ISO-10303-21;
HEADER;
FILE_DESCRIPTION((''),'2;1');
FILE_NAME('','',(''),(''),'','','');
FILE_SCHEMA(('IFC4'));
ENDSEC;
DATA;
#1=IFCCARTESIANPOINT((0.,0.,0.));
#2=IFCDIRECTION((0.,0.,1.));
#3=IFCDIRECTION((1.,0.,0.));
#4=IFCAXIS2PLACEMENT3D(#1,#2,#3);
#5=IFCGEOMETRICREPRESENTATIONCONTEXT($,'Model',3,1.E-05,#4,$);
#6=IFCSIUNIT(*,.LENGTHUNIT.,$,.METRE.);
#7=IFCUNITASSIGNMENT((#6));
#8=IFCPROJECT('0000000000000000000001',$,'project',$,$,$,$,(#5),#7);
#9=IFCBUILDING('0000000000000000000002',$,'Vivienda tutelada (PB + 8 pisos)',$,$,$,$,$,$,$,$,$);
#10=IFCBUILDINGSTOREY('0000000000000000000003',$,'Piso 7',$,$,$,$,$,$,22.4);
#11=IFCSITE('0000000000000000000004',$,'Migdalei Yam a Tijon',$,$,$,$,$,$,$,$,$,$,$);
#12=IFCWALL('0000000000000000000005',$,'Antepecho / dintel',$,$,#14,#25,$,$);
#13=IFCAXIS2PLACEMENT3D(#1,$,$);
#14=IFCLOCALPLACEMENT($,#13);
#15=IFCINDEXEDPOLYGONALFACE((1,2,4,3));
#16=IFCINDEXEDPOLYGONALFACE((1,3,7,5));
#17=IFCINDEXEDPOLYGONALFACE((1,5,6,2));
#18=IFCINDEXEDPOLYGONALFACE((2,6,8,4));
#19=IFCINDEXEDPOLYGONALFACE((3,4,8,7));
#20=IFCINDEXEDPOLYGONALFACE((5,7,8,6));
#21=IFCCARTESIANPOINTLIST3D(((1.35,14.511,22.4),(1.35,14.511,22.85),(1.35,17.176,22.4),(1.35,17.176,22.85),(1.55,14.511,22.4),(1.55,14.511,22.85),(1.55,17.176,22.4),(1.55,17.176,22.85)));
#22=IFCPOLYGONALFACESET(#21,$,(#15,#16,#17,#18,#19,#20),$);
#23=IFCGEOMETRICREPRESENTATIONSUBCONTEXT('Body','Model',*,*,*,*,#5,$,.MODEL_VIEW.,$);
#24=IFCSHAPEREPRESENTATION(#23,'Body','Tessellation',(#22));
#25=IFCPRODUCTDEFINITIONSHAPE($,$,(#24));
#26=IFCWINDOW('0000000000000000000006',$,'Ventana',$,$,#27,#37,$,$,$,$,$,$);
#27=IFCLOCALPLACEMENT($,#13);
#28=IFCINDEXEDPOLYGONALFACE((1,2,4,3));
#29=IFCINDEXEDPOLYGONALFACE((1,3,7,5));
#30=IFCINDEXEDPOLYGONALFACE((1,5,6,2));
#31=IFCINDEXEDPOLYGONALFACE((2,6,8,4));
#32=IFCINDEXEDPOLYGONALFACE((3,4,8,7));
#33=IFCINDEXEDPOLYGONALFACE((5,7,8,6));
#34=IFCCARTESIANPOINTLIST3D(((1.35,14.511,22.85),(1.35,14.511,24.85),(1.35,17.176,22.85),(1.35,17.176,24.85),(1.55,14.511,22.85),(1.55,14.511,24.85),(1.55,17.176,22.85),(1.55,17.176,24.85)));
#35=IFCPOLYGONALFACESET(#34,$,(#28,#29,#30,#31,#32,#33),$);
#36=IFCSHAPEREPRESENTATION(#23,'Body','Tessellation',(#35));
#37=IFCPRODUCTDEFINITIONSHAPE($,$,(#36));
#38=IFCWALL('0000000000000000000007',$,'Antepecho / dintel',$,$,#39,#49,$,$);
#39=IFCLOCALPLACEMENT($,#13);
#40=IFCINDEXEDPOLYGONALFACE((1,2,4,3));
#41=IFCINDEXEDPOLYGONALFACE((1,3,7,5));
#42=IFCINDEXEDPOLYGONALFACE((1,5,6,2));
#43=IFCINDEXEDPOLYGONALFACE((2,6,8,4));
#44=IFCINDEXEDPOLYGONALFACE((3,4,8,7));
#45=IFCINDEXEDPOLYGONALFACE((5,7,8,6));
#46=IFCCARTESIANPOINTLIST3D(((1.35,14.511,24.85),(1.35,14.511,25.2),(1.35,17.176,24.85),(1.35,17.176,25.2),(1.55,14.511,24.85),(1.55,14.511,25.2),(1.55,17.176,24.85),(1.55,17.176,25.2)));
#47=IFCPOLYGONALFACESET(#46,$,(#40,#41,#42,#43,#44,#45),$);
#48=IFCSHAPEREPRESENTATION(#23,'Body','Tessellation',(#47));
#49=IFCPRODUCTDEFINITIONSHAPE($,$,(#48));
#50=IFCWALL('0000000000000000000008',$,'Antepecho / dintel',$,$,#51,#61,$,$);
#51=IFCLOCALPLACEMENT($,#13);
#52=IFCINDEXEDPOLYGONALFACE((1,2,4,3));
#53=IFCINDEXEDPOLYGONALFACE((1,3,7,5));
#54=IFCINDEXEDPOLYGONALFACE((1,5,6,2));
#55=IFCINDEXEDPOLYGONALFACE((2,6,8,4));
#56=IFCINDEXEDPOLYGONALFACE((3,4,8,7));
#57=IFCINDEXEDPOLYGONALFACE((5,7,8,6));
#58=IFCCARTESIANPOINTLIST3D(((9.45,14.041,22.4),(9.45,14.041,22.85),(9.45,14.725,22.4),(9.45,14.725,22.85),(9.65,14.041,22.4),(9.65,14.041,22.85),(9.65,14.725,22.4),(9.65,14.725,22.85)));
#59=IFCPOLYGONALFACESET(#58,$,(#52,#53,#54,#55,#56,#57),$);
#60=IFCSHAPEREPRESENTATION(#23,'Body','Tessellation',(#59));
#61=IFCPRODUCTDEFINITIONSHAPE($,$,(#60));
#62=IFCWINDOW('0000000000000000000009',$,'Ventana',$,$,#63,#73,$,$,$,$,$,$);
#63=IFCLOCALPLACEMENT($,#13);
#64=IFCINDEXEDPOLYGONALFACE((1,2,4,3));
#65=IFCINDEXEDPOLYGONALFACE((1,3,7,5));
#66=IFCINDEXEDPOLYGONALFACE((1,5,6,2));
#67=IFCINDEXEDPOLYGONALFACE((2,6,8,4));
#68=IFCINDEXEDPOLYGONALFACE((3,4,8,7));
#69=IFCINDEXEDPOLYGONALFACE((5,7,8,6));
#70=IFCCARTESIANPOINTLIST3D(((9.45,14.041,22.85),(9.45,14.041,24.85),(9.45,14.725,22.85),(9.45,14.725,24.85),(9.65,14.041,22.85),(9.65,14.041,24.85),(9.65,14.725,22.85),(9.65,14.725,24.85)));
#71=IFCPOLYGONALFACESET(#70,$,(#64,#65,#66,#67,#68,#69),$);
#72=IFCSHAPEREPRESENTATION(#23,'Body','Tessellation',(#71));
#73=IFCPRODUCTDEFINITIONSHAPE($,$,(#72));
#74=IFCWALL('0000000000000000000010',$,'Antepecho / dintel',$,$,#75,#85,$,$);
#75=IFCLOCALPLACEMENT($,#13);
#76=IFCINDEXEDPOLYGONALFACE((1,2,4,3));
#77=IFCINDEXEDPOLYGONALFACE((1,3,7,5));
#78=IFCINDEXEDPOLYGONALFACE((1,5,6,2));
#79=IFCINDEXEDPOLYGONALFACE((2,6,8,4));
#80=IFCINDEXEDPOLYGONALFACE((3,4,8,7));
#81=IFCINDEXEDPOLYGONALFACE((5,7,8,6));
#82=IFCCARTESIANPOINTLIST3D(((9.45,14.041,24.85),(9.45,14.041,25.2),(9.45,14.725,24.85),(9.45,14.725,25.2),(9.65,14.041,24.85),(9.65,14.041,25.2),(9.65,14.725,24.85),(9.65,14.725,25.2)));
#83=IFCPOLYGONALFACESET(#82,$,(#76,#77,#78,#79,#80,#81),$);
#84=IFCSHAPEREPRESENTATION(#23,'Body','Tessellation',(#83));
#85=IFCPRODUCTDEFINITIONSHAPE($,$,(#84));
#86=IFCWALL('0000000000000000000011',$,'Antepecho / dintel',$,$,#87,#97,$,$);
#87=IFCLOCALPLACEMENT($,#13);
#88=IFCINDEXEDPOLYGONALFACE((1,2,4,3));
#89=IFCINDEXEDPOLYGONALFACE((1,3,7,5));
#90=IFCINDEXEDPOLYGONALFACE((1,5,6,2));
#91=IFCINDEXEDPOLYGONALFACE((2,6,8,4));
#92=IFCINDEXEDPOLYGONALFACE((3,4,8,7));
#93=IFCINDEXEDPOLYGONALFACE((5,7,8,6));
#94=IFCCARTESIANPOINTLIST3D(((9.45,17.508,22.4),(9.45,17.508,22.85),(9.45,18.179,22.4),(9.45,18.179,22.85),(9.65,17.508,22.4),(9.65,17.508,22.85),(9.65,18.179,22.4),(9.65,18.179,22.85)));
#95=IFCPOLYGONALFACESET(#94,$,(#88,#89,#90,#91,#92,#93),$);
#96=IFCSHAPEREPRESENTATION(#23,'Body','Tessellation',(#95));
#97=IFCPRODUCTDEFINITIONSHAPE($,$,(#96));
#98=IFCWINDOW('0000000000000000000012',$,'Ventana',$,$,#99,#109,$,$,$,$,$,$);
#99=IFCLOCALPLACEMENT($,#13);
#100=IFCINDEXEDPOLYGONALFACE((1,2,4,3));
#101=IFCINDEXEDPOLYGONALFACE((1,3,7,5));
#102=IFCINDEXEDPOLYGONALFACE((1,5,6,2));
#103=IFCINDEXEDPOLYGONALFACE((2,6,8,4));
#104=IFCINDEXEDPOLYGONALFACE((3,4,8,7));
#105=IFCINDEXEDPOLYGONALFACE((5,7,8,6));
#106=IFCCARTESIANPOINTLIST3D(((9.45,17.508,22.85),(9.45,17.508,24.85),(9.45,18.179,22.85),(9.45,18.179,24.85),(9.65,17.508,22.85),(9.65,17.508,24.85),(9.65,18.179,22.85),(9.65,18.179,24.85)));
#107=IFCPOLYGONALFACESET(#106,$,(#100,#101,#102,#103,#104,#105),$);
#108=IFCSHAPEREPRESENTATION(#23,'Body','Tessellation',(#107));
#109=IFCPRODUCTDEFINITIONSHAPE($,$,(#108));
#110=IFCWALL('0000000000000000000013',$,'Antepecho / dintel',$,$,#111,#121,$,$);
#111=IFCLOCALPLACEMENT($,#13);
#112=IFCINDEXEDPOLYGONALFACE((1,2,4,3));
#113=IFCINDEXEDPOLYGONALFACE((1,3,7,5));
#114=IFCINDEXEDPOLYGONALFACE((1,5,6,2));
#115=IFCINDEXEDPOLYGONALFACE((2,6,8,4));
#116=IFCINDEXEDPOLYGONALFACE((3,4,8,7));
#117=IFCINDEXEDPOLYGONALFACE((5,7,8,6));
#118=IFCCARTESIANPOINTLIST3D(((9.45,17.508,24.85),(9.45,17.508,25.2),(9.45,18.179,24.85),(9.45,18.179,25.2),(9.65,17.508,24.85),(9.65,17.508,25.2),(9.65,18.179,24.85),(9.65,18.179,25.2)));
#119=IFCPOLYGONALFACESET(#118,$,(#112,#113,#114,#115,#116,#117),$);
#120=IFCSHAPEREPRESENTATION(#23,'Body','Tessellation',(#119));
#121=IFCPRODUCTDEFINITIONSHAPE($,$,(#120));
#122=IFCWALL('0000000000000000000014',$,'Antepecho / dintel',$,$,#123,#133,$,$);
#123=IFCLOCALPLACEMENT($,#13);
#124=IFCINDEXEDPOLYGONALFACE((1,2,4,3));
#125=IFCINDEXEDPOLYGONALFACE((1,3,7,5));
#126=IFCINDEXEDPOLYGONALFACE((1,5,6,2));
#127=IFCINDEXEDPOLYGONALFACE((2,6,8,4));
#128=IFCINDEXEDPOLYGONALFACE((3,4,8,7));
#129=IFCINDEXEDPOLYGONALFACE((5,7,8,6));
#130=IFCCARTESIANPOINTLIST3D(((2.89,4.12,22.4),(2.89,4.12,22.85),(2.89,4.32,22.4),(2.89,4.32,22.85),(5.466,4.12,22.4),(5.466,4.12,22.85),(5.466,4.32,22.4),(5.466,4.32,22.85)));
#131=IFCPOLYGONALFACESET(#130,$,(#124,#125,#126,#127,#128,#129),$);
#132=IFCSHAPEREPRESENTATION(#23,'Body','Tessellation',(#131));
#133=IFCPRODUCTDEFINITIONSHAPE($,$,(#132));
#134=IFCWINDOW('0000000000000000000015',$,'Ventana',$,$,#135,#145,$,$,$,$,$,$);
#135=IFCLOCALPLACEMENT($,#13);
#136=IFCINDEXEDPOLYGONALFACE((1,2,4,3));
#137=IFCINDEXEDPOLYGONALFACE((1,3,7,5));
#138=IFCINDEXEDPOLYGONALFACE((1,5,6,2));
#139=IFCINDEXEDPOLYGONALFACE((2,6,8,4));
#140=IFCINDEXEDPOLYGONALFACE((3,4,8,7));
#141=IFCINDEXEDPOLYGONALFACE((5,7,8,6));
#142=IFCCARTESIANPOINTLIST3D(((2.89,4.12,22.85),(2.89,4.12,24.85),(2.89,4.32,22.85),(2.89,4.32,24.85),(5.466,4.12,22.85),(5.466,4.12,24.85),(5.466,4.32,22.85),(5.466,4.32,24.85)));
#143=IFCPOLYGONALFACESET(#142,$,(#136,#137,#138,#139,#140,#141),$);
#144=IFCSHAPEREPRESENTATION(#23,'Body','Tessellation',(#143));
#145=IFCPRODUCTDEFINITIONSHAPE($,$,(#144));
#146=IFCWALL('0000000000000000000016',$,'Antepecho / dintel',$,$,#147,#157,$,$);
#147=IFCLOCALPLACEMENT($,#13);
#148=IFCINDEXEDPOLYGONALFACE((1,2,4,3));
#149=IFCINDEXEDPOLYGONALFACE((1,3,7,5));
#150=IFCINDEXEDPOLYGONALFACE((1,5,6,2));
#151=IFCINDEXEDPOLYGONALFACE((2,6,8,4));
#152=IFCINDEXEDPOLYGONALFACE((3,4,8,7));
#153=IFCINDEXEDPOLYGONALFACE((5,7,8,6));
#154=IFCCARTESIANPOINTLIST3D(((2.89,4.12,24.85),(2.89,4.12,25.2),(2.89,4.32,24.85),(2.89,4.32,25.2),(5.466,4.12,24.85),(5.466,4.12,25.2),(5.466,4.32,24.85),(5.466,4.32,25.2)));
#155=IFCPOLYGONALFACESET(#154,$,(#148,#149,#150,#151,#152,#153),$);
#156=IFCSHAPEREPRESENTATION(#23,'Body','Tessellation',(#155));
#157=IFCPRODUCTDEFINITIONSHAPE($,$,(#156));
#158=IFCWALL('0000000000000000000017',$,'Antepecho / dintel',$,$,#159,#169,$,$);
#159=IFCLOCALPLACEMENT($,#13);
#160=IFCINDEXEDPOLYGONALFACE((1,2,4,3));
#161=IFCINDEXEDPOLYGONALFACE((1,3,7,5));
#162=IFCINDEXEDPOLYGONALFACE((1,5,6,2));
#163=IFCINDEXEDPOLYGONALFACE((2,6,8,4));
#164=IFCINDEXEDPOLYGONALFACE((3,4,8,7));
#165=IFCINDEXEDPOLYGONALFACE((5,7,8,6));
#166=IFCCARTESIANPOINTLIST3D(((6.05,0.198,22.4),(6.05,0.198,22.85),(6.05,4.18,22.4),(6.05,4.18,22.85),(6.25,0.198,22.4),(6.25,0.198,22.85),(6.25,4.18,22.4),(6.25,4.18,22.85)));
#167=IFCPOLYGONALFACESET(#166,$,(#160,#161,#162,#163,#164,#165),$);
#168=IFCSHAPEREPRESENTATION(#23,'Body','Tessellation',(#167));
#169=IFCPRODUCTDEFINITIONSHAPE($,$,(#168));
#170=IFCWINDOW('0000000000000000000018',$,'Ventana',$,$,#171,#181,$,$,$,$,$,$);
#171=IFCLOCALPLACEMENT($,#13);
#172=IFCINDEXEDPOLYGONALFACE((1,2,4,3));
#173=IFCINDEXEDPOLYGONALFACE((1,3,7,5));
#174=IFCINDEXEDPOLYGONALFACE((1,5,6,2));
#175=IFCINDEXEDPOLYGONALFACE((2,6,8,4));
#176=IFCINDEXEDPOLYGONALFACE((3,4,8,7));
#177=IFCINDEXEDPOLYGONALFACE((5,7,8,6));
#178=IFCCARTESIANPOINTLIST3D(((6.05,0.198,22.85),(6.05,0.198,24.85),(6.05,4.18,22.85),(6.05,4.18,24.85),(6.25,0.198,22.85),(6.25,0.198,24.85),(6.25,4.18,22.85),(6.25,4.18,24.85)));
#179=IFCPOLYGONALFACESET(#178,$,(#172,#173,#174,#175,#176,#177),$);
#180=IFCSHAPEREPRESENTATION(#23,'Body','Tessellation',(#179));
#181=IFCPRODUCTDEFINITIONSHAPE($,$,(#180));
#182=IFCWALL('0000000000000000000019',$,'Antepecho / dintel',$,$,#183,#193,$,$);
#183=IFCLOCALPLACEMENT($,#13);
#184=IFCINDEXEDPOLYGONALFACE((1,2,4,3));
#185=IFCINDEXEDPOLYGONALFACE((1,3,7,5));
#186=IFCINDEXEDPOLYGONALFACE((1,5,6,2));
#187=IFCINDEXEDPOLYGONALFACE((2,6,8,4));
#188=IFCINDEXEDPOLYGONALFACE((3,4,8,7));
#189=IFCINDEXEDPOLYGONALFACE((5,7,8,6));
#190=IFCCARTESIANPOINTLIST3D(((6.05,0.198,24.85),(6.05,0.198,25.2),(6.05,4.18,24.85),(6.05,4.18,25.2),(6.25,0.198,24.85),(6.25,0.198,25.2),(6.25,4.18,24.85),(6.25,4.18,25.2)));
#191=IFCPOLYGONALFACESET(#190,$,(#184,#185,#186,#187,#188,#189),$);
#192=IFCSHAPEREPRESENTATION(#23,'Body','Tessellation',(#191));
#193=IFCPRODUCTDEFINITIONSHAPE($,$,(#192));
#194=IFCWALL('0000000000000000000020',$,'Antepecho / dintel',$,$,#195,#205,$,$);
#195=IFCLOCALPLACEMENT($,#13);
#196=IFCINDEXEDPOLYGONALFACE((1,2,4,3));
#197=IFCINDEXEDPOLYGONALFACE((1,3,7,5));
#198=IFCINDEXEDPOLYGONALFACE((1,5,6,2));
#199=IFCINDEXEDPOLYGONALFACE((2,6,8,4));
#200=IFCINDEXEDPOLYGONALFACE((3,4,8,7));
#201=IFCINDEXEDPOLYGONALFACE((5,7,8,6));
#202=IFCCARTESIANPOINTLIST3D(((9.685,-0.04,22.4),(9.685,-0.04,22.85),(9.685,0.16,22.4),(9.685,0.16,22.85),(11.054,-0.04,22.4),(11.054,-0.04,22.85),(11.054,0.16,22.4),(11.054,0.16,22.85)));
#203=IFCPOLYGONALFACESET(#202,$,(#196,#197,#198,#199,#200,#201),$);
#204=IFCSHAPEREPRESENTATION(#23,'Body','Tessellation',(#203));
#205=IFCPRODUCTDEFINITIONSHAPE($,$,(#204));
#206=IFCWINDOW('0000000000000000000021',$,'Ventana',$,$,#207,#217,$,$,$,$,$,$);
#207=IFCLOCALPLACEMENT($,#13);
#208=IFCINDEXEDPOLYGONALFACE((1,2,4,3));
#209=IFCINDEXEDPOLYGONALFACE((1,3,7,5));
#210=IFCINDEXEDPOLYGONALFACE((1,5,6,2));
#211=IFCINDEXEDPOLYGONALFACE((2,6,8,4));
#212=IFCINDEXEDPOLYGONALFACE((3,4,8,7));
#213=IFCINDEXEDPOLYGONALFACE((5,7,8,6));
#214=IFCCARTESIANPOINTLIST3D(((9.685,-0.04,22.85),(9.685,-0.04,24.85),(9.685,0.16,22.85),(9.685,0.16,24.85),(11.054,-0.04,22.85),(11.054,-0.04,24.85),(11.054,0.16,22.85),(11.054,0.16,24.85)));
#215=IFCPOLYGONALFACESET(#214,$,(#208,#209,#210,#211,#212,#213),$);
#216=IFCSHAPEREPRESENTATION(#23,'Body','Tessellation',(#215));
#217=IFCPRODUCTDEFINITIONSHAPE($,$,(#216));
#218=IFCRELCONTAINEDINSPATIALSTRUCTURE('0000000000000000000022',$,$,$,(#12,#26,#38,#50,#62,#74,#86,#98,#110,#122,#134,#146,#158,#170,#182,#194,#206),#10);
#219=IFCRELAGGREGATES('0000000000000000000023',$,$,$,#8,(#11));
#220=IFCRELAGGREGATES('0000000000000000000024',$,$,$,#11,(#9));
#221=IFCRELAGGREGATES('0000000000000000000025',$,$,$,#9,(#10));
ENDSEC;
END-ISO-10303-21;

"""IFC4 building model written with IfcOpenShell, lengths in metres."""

from ifc_helpers import new_model, si_unit, frame, origin_with_axes, context, subcontext, project, spatial, line, indexed_curve, outline, extrude, element, save


model = new_model("IFC4")

# Units and contexts
model_context = context("Model", 3, precision=1e-05, world=origin_with_axes())
body_context = subcontext(model_context, "Body", "Model", "MODEL_VIEW")
ifc_project = project(units=[si_unit("LENGTHUNIT", "METRE")], contexts=[model_context])

# Site, building, storey
site = spatial("IfcSite", under=ifc_project, Name="Migdalei Yam a Tijon")
building = spatial("IfcBuilding", under=site, Name="Vivienda tutelada (PB + 8 pisos)")
storey = spatial("IfcBuildingStorey", under=building, Name="Piso 7", Elevation=22.4)

# Wall
element("IfcWall", 1, inside=storey, Name="Antepecho / dintel", context=body_context, shape_type="SweptSolid", body=[
    extrude(outline(indexed_curve([(0.0, 0.0), (0.2, 0.0), (0.2, 2.665), (0.0, 2.665)], segments=[line(1, 2, 3, 4, 1)])), frame((1.35, 14.511, 22.4), z_axis=(0.0, 0.0, 1.0), x_axis=(1.0, 0.0, 0.0)), (0.0, 0.0, 1.0), 0.45),
])

# Window
element("IfcWindow", 2, inside=storey, Name="Ventana", context=body_context, shape_type="SweptSolid", body=[
    extrude(outline(indexed_curve([(0.0, 0.0), (0.2, 0.0), (0.2, 2.665), (0.0, 2.665)], segments=[line(1, 2, 3, 4, 1)])), frame((1.35, 14.511, 22.85), z_axis=(0.0, 0.0, 1.0), x_axis=(1.0, 0.0, 0.0)), (0.0, 0.0, 1.0), 2.0),
])

# Walls
element("IfcWall", 3, inside=storey, Name="Antepecho / dintel", context=body_context, shape_type="SweptSolid", body=[
    extrude(outline(indexed_curve([(0.0, 0.0), (0.2, 0.0), (0.2, 2.665), (0.0, 2.665)], segments=[line(1, 2, 3, 4, 1)])), frame((1.35, 14.511, 24.85), z_axis=(0.0, 0.0, 1.0), x_axis=(1.0, 0.0, 0.0)), (0.0, 0.0, 1.0), 0.35),
])
element("IfcWall", 4, inside=storey, Name="Antepecho / dintel", context=body_context, shape_type="SweptSolid", body=[
    extrude(outline(indexed_curve([(0.0, 0.0), (0.2, 0.0), (0.2, 0.684), (0.0, 0.684)], segments=[line(1, 2, 3, 4, 1)])), frame((9.45, 14.041, 22.4), z_axis=(0.0, 0.0, 1.0), x_axis=(1.0, 0.0, 0.0)), (0.0, 0.0, 1.0), 0.45),
])

# Window
element("IfcWindow", 5, inside=storey, Name="Ventana", context=body_context, shape_type="SweptSolid", body=[
    extrude(outline(indexed_curve([(0.0, 0.0), (0.2, 0.0), (0.2, 0.684), (0.0, 0.684)], segments=[line(1, 2, 3, 4, 1)])), frame((9.45, 14.041, 22.85), z_axis=(0.0, 0.0, 1.0), x_axis=(1.0, 0.0, 0.0)), (0.0, 0.0, 1.0), 2.0),
])

# Walls
element("IfcWall", 6, inside=storey, Name="Antepecho / dintel", context=body_context, shape_type="SweptSolid", body=[
    extrude(outline(indexed_curve([(0.0, 0.0), (0.2, 0.0), (0.2, 0.684), (0.0, 0.684)], segments=[line(1, 2, 3, 4, 1)])), frame((9.45, 14.041, 24.85), z_axis=(0.0, 0.0, 1.0), x_axis=(1.0, 0.0, 0.0)), (0.0, 0.0, 1.0), 0.35),
])
element("IfcWall", 7, inside=storey, Name="Antepecho / dintel", context=body_context, shape_type="SweptSolid", body=[
    extrude(outline(indexed_curve([(0.0, 0.0), (0.2, 0.0), (0.2, 0.671), (0.0, 0.671)], segments=[line(1, 2, 3, 4, 1)])), frame((9.45, 17.508, 22.4), z_axis=(0.0, 0.0, 1.0), x_axis=(1.0, 0.0, 0.0)), (0.0, 0.0, 1.0), 0.45),
])

# Window
element("IfcWindow", 8, inside=storey, Name="Ventana", context=body_context, shape_type="SweptSolid", body=[
    extrude(outline(indexed_curve([(0.0, 0.0), (0.2, 0.0), (0.2, 0.671), (0.0, 0.671)], segments=[line(1, 2, 3, 4, 1)])), frame((9.45, 17.508, 22.85), z_axis=(0.0, 0.0, 1.0), x_axis=(1.0, 0.0, 0.0)), (0.0, 0.0, 1.0), 2.0),
])

# Walls
element("IfcWall", 9, inside=storey, Name="Antepecho / dintel", context=body_context, shape_type="SweptSolid", body=[
    extrude(outline(indexed_curve([(0.0, 0.0), (0.2, 0.0), (0.2, 0.671), (0.0, 0.671)], segments=[line(1, 2, 3, 4, 1)])), frame((9.45, 17.508, 24.85), z_axis=(0.0, 0.0, 1.0), x_axis=(1.0, 0.0, 0.0)), (0.0, 0.0, 1.0), 0.35),
])
element("IfcWall", 10, inside=storey, Name="Antepecho / dintel", context=body_context, shape_type="SweptSolid", body=[
    extrude(outline(indexed_curve([(0.0, 0.0), (2.576, 0.0), (2.576, 0.2), (0.0, 0.2)], segments=[line(1, 2, 3, 4, 1)])), frame((2.89, 4.12, 22.4), z_axis=(0.0, 0.0, 1.0), x_axis=(1.0, 0.0, 0.0)), (0.0, 0.0, 1.0), 0.45),
])

# Window
element("IfcWindow", 11, inside=storey, Name="Ventana", context=body_context, shape_type="SweptSolid", body=[
    extrude(outline(indexed_curve([(0.0, 0.0), (2.576, 0.0), (2.576, 0.2), (0.0, 0.2)], segments=[line(1, 2, 3, 4, 1)])), frame((2.89, 4.12, 22.85), z_axis=(0.0, 0.0, 1.0), x_axis=(1.0, 0.0, 0.0)), (0.0, 0.0, 1.0), 2.0),
])

# Walls
element("IfcWall", 12, inside=storey, Name="Antepecho / dintel", context=body_context, shape_type="SweptSolid", body=[
    extrude(outline(indexed_curve([(0.0, 0.0), (2.576, 0.0), (2.576, 0.2), (0.0, 0.2)], segments=[line(1, 2, 3, 4, 1)])), frame((2.89, 4.12, 24.85), z_axis=(0.0, 0.0, 1.0), x_axis=(1.0, 0.0, 0.0)), (0.0, 0.0, 1.0), 0.35),
])
element("IfcWall", 13, inside=storey, Name="Antepecho / dintel", context=body_context, shape_type="SweptSolid", body=[
    extrude(outline(indexed_curve([(0.0, 0.0), (0.2, 0.0), (0.2, 3.982), (0.0, 3.982)], segments=[line(1, 2, 3, 4, 1)])), frame((6.05, 0.198, 22.4), z_axis=(0.0, 0.0, 1.0), x_axis=(1.0, 0.0, 0.0)), (0.0, 0.0, 1.0), 0.45),
])

# Window
element("IfcWindow", 14, inside=storey, Name="Ventana", context=body_context, shape_type="SweptSolid", body=[
    extrude(outline(indexed_curve([(0.0, 0.0), (0.2, 0.0), (0.2, 3.982), (0.0, 3.982)], segments=[line(1, 2, 3, 4, 1)])), frame((6.05, 0.198, 22.85), z_axis=(0.0, 0.0, 1.0), x_axis=(1.0, 0.0, 0.0)), (0.0, 0.0, 1.0), 2.0),
])

# Walls
element("IfcWall", 15, inside=storey, Name="Antepecho / dintel", context=body_context, shape_type="SweptSolid", body=[
    extrude(outline(indexed_curve([(0.0, 0.0), (0.2, 0.0), (0.2, 3.982), (0.0, 3.982)], segments=[line(1, 2, 3, 4, 1)])), frame((6.05, 0.198, 24.85), z_axis=(0.0, 0.0, 1.0), x_axis=(1.0, 0.0, 0.0)), (0.0, 0.0, 1.0), 0.35),
])
element("IfcWall", 16, inside=storey, Name="Antepecho / dintel", context=body_context, shape_type="SweptSolid", body=[
    extrude(outline(indexed_curve([(0.0, 0.0), (1.369, 0.0), (1.369, 0.2), (0.0, 0.2)], segments=[line(1, 2, 3, 4, 1)])), frame((9.685, -0.04, 22.4), z_axis=(0.0, 0.0, 1.0), x_axis=(1.0, 0.0, 0.0)), (0.0, 0.0, 1.0), 0.45),
])

# Window
element("IfcWindow", 17, inside=storey, Name="Ventana", context=body_context, shape_type="SweptSolid", body=[
    extrude(outline(indexed_curve([(0.0, 0.0), (1.369, 0.0), (1.369, 0.2), (0.0, 0.2)], segments=[line(1, 2, 3, 4, 1)])), frame((9.685, -0.04, 22.85), z_axis=(0.0, 0.0, 1.0), x_axis=(1.0, 0.0, 0.0)), (0.0, 0.0, 1.0), 2.0),
])

save(model, "model.ifc")
